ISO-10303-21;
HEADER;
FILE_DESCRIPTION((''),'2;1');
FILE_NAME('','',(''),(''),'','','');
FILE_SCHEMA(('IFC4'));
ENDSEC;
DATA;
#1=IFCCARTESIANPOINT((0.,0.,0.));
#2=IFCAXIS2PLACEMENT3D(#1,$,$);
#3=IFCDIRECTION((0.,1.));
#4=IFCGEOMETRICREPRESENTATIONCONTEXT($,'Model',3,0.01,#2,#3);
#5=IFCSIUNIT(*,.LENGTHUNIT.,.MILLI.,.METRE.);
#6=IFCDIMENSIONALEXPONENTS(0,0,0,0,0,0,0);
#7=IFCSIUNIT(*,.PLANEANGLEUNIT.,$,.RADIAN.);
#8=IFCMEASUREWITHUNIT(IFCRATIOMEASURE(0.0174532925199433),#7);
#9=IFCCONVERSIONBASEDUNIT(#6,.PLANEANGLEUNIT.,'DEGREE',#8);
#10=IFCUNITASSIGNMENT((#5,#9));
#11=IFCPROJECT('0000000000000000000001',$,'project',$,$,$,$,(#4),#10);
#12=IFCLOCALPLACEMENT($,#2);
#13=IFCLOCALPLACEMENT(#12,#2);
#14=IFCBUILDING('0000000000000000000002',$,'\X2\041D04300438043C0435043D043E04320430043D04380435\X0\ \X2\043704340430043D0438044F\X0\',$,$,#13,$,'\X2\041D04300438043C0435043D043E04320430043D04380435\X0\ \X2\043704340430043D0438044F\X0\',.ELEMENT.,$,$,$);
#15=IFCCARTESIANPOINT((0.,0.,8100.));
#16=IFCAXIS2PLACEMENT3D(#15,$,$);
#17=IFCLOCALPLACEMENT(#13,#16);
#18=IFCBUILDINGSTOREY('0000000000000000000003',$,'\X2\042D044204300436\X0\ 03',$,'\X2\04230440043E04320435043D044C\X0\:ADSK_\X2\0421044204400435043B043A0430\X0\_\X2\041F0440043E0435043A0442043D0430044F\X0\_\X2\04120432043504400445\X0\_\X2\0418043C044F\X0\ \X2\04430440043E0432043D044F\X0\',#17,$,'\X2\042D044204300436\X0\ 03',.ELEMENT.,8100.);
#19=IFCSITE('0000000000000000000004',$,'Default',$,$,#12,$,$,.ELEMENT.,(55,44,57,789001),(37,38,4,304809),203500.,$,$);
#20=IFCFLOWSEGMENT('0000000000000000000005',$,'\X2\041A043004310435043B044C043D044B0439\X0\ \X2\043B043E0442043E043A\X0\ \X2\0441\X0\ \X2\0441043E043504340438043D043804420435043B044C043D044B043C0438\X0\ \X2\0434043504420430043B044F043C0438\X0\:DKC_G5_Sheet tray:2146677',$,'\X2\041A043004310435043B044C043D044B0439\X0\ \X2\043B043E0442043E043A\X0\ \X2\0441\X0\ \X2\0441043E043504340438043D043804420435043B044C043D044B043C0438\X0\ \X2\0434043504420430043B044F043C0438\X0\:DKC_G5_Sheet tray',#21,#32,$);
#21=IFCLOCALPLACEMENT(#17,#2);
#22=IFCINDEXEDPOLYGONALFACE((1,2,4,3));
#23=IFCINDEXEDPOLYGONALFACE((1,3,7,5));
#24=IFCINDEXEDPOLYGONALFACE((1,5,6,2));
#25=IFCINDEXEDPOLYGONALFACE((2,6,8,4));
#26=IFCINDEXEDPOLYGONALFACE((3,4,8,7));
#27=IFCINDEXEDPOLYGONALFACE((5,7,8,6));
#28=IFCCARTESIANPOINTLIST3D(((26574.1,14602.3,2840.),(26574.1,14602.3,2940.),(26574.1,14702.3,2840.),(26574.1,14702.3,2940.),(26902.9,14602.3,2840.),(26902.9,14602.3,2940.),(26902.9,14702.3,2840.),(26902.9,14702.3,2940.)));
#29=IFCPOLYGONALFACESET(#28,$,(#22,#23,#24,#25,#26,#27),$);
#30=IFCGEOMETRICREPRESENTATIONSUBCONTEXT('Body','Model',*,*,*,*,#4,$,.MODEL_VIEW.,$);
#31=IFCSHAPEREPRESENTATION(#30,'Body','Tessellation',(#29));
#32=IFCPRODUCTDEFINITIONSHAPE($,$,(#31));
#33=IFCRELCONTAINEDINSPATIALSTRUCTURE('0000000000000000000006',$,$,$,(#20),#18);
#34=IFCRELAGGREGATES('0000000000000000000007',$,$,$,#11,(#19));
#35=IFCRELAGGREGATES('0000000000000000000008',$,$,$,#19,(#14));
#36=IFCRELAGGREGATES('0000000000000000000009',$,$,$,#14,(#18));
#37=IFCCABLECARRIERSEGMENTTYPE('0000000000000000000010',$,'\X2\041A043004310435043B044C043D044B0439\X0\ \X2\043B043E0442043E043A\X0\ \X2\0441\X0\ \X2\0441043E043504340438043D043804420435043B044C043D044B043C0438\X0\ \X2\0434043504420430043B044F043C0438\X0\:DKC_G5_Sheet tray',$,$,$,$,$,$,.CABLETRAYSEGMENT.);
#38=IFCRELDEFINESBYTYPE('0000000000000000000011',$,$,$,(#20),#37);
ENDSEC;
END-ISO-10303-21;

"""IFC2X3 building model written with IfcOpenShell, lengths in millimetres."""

from ifc_helpers import new_model, entity, si_unit, converted_unit, direction, frame, origin, origin_2d_with_axis, place, context, subcontext, project, spatial, rectangle, extrude, type_object, element, save


model = new_model("IFC2X3")

# Units and contexts
model_context = context("Model", 3, precision=0.01, world=origin(), true_north=direction((0.0, 1.0)))
body_context = subcontext(model_context, "Body", "Model", "MODEL_VIEW")
ifc_project = project(units=[si_unit("LENGTHUNIT", "METRE", prefix="MILLI"), converted_unit("PLANEANGLEUNIT", "DEGREE", entity("IfcRatioMeasure", 0.0174532925199433), si_unit("PLANEANGLEUNIT", "RADIAN"), dimensions=[0, 0, 0, 0, 0, 0, 0])], contexts=[model_context])

# Site, building, storey
site_placement = place(None, frame((0.0, 0.0, 0.0)))
site = spatial("IfcSite", under=ifc_project, at=site_placement, Name="Default", CompositionType="ELEMENT", RefLatitude=(55, 44, 57, 789001), RefLongitude=(37, 38, 4, 304809), RefElevation=203500.0)
building_placement = place(site_placement, origin())
building = spatial("IfcBuilding", under=site, at=building_placement, Name="Наименование здания", LongName="Наименование здания", CompositionType="ELEMENT")
storey_placement = place(building_placement, frame((0.0, 0.0, 8100.0)))
storey = spatial("IfcBuildingStorey", under=building, at=storey_placement, Name="Этаж 03", ObjectType="Уровень:ADSK_Стрелка_Проектная_Вверх_Имя уровня", LongName="Этаж 03", CompositionType="ELEMENT", Elevation=8100.0)

# Flow segment
cable_carrier_segment_type = type_object("IfcCableCarrierSegmentType", Name="Кабельный лоток с соединительными деталями:DKC_G5_Sheet tray", PredefinedType="CABLETRAYSEGMENT")
flow_segment_1_placement = place(storey_placement, frame((26574.1, 14602.3, 2840.0)))
element("IfcFlowSegment", 1, at=flow_segment_1_placement, inside=storey, type_object=cable_carrier_segment_type, Name="Кабельный лоток с соединительными деталями:DKC_G5_Sheet tray:2146677", ObjectType="Кабельный лоток с соединительными деталями:DKC_G5_Sheet tray", context=body_context, shape_type="SweptSolid", body=[
    extrude(rectangle(XDim=328.8, YDim=100.0, at=origin_2d_with_axis()), frame((164.4, 50.0, 0.0)), (0.0, 0.0, 1.0), 100.0),
])

save(model, "model.ifc")
